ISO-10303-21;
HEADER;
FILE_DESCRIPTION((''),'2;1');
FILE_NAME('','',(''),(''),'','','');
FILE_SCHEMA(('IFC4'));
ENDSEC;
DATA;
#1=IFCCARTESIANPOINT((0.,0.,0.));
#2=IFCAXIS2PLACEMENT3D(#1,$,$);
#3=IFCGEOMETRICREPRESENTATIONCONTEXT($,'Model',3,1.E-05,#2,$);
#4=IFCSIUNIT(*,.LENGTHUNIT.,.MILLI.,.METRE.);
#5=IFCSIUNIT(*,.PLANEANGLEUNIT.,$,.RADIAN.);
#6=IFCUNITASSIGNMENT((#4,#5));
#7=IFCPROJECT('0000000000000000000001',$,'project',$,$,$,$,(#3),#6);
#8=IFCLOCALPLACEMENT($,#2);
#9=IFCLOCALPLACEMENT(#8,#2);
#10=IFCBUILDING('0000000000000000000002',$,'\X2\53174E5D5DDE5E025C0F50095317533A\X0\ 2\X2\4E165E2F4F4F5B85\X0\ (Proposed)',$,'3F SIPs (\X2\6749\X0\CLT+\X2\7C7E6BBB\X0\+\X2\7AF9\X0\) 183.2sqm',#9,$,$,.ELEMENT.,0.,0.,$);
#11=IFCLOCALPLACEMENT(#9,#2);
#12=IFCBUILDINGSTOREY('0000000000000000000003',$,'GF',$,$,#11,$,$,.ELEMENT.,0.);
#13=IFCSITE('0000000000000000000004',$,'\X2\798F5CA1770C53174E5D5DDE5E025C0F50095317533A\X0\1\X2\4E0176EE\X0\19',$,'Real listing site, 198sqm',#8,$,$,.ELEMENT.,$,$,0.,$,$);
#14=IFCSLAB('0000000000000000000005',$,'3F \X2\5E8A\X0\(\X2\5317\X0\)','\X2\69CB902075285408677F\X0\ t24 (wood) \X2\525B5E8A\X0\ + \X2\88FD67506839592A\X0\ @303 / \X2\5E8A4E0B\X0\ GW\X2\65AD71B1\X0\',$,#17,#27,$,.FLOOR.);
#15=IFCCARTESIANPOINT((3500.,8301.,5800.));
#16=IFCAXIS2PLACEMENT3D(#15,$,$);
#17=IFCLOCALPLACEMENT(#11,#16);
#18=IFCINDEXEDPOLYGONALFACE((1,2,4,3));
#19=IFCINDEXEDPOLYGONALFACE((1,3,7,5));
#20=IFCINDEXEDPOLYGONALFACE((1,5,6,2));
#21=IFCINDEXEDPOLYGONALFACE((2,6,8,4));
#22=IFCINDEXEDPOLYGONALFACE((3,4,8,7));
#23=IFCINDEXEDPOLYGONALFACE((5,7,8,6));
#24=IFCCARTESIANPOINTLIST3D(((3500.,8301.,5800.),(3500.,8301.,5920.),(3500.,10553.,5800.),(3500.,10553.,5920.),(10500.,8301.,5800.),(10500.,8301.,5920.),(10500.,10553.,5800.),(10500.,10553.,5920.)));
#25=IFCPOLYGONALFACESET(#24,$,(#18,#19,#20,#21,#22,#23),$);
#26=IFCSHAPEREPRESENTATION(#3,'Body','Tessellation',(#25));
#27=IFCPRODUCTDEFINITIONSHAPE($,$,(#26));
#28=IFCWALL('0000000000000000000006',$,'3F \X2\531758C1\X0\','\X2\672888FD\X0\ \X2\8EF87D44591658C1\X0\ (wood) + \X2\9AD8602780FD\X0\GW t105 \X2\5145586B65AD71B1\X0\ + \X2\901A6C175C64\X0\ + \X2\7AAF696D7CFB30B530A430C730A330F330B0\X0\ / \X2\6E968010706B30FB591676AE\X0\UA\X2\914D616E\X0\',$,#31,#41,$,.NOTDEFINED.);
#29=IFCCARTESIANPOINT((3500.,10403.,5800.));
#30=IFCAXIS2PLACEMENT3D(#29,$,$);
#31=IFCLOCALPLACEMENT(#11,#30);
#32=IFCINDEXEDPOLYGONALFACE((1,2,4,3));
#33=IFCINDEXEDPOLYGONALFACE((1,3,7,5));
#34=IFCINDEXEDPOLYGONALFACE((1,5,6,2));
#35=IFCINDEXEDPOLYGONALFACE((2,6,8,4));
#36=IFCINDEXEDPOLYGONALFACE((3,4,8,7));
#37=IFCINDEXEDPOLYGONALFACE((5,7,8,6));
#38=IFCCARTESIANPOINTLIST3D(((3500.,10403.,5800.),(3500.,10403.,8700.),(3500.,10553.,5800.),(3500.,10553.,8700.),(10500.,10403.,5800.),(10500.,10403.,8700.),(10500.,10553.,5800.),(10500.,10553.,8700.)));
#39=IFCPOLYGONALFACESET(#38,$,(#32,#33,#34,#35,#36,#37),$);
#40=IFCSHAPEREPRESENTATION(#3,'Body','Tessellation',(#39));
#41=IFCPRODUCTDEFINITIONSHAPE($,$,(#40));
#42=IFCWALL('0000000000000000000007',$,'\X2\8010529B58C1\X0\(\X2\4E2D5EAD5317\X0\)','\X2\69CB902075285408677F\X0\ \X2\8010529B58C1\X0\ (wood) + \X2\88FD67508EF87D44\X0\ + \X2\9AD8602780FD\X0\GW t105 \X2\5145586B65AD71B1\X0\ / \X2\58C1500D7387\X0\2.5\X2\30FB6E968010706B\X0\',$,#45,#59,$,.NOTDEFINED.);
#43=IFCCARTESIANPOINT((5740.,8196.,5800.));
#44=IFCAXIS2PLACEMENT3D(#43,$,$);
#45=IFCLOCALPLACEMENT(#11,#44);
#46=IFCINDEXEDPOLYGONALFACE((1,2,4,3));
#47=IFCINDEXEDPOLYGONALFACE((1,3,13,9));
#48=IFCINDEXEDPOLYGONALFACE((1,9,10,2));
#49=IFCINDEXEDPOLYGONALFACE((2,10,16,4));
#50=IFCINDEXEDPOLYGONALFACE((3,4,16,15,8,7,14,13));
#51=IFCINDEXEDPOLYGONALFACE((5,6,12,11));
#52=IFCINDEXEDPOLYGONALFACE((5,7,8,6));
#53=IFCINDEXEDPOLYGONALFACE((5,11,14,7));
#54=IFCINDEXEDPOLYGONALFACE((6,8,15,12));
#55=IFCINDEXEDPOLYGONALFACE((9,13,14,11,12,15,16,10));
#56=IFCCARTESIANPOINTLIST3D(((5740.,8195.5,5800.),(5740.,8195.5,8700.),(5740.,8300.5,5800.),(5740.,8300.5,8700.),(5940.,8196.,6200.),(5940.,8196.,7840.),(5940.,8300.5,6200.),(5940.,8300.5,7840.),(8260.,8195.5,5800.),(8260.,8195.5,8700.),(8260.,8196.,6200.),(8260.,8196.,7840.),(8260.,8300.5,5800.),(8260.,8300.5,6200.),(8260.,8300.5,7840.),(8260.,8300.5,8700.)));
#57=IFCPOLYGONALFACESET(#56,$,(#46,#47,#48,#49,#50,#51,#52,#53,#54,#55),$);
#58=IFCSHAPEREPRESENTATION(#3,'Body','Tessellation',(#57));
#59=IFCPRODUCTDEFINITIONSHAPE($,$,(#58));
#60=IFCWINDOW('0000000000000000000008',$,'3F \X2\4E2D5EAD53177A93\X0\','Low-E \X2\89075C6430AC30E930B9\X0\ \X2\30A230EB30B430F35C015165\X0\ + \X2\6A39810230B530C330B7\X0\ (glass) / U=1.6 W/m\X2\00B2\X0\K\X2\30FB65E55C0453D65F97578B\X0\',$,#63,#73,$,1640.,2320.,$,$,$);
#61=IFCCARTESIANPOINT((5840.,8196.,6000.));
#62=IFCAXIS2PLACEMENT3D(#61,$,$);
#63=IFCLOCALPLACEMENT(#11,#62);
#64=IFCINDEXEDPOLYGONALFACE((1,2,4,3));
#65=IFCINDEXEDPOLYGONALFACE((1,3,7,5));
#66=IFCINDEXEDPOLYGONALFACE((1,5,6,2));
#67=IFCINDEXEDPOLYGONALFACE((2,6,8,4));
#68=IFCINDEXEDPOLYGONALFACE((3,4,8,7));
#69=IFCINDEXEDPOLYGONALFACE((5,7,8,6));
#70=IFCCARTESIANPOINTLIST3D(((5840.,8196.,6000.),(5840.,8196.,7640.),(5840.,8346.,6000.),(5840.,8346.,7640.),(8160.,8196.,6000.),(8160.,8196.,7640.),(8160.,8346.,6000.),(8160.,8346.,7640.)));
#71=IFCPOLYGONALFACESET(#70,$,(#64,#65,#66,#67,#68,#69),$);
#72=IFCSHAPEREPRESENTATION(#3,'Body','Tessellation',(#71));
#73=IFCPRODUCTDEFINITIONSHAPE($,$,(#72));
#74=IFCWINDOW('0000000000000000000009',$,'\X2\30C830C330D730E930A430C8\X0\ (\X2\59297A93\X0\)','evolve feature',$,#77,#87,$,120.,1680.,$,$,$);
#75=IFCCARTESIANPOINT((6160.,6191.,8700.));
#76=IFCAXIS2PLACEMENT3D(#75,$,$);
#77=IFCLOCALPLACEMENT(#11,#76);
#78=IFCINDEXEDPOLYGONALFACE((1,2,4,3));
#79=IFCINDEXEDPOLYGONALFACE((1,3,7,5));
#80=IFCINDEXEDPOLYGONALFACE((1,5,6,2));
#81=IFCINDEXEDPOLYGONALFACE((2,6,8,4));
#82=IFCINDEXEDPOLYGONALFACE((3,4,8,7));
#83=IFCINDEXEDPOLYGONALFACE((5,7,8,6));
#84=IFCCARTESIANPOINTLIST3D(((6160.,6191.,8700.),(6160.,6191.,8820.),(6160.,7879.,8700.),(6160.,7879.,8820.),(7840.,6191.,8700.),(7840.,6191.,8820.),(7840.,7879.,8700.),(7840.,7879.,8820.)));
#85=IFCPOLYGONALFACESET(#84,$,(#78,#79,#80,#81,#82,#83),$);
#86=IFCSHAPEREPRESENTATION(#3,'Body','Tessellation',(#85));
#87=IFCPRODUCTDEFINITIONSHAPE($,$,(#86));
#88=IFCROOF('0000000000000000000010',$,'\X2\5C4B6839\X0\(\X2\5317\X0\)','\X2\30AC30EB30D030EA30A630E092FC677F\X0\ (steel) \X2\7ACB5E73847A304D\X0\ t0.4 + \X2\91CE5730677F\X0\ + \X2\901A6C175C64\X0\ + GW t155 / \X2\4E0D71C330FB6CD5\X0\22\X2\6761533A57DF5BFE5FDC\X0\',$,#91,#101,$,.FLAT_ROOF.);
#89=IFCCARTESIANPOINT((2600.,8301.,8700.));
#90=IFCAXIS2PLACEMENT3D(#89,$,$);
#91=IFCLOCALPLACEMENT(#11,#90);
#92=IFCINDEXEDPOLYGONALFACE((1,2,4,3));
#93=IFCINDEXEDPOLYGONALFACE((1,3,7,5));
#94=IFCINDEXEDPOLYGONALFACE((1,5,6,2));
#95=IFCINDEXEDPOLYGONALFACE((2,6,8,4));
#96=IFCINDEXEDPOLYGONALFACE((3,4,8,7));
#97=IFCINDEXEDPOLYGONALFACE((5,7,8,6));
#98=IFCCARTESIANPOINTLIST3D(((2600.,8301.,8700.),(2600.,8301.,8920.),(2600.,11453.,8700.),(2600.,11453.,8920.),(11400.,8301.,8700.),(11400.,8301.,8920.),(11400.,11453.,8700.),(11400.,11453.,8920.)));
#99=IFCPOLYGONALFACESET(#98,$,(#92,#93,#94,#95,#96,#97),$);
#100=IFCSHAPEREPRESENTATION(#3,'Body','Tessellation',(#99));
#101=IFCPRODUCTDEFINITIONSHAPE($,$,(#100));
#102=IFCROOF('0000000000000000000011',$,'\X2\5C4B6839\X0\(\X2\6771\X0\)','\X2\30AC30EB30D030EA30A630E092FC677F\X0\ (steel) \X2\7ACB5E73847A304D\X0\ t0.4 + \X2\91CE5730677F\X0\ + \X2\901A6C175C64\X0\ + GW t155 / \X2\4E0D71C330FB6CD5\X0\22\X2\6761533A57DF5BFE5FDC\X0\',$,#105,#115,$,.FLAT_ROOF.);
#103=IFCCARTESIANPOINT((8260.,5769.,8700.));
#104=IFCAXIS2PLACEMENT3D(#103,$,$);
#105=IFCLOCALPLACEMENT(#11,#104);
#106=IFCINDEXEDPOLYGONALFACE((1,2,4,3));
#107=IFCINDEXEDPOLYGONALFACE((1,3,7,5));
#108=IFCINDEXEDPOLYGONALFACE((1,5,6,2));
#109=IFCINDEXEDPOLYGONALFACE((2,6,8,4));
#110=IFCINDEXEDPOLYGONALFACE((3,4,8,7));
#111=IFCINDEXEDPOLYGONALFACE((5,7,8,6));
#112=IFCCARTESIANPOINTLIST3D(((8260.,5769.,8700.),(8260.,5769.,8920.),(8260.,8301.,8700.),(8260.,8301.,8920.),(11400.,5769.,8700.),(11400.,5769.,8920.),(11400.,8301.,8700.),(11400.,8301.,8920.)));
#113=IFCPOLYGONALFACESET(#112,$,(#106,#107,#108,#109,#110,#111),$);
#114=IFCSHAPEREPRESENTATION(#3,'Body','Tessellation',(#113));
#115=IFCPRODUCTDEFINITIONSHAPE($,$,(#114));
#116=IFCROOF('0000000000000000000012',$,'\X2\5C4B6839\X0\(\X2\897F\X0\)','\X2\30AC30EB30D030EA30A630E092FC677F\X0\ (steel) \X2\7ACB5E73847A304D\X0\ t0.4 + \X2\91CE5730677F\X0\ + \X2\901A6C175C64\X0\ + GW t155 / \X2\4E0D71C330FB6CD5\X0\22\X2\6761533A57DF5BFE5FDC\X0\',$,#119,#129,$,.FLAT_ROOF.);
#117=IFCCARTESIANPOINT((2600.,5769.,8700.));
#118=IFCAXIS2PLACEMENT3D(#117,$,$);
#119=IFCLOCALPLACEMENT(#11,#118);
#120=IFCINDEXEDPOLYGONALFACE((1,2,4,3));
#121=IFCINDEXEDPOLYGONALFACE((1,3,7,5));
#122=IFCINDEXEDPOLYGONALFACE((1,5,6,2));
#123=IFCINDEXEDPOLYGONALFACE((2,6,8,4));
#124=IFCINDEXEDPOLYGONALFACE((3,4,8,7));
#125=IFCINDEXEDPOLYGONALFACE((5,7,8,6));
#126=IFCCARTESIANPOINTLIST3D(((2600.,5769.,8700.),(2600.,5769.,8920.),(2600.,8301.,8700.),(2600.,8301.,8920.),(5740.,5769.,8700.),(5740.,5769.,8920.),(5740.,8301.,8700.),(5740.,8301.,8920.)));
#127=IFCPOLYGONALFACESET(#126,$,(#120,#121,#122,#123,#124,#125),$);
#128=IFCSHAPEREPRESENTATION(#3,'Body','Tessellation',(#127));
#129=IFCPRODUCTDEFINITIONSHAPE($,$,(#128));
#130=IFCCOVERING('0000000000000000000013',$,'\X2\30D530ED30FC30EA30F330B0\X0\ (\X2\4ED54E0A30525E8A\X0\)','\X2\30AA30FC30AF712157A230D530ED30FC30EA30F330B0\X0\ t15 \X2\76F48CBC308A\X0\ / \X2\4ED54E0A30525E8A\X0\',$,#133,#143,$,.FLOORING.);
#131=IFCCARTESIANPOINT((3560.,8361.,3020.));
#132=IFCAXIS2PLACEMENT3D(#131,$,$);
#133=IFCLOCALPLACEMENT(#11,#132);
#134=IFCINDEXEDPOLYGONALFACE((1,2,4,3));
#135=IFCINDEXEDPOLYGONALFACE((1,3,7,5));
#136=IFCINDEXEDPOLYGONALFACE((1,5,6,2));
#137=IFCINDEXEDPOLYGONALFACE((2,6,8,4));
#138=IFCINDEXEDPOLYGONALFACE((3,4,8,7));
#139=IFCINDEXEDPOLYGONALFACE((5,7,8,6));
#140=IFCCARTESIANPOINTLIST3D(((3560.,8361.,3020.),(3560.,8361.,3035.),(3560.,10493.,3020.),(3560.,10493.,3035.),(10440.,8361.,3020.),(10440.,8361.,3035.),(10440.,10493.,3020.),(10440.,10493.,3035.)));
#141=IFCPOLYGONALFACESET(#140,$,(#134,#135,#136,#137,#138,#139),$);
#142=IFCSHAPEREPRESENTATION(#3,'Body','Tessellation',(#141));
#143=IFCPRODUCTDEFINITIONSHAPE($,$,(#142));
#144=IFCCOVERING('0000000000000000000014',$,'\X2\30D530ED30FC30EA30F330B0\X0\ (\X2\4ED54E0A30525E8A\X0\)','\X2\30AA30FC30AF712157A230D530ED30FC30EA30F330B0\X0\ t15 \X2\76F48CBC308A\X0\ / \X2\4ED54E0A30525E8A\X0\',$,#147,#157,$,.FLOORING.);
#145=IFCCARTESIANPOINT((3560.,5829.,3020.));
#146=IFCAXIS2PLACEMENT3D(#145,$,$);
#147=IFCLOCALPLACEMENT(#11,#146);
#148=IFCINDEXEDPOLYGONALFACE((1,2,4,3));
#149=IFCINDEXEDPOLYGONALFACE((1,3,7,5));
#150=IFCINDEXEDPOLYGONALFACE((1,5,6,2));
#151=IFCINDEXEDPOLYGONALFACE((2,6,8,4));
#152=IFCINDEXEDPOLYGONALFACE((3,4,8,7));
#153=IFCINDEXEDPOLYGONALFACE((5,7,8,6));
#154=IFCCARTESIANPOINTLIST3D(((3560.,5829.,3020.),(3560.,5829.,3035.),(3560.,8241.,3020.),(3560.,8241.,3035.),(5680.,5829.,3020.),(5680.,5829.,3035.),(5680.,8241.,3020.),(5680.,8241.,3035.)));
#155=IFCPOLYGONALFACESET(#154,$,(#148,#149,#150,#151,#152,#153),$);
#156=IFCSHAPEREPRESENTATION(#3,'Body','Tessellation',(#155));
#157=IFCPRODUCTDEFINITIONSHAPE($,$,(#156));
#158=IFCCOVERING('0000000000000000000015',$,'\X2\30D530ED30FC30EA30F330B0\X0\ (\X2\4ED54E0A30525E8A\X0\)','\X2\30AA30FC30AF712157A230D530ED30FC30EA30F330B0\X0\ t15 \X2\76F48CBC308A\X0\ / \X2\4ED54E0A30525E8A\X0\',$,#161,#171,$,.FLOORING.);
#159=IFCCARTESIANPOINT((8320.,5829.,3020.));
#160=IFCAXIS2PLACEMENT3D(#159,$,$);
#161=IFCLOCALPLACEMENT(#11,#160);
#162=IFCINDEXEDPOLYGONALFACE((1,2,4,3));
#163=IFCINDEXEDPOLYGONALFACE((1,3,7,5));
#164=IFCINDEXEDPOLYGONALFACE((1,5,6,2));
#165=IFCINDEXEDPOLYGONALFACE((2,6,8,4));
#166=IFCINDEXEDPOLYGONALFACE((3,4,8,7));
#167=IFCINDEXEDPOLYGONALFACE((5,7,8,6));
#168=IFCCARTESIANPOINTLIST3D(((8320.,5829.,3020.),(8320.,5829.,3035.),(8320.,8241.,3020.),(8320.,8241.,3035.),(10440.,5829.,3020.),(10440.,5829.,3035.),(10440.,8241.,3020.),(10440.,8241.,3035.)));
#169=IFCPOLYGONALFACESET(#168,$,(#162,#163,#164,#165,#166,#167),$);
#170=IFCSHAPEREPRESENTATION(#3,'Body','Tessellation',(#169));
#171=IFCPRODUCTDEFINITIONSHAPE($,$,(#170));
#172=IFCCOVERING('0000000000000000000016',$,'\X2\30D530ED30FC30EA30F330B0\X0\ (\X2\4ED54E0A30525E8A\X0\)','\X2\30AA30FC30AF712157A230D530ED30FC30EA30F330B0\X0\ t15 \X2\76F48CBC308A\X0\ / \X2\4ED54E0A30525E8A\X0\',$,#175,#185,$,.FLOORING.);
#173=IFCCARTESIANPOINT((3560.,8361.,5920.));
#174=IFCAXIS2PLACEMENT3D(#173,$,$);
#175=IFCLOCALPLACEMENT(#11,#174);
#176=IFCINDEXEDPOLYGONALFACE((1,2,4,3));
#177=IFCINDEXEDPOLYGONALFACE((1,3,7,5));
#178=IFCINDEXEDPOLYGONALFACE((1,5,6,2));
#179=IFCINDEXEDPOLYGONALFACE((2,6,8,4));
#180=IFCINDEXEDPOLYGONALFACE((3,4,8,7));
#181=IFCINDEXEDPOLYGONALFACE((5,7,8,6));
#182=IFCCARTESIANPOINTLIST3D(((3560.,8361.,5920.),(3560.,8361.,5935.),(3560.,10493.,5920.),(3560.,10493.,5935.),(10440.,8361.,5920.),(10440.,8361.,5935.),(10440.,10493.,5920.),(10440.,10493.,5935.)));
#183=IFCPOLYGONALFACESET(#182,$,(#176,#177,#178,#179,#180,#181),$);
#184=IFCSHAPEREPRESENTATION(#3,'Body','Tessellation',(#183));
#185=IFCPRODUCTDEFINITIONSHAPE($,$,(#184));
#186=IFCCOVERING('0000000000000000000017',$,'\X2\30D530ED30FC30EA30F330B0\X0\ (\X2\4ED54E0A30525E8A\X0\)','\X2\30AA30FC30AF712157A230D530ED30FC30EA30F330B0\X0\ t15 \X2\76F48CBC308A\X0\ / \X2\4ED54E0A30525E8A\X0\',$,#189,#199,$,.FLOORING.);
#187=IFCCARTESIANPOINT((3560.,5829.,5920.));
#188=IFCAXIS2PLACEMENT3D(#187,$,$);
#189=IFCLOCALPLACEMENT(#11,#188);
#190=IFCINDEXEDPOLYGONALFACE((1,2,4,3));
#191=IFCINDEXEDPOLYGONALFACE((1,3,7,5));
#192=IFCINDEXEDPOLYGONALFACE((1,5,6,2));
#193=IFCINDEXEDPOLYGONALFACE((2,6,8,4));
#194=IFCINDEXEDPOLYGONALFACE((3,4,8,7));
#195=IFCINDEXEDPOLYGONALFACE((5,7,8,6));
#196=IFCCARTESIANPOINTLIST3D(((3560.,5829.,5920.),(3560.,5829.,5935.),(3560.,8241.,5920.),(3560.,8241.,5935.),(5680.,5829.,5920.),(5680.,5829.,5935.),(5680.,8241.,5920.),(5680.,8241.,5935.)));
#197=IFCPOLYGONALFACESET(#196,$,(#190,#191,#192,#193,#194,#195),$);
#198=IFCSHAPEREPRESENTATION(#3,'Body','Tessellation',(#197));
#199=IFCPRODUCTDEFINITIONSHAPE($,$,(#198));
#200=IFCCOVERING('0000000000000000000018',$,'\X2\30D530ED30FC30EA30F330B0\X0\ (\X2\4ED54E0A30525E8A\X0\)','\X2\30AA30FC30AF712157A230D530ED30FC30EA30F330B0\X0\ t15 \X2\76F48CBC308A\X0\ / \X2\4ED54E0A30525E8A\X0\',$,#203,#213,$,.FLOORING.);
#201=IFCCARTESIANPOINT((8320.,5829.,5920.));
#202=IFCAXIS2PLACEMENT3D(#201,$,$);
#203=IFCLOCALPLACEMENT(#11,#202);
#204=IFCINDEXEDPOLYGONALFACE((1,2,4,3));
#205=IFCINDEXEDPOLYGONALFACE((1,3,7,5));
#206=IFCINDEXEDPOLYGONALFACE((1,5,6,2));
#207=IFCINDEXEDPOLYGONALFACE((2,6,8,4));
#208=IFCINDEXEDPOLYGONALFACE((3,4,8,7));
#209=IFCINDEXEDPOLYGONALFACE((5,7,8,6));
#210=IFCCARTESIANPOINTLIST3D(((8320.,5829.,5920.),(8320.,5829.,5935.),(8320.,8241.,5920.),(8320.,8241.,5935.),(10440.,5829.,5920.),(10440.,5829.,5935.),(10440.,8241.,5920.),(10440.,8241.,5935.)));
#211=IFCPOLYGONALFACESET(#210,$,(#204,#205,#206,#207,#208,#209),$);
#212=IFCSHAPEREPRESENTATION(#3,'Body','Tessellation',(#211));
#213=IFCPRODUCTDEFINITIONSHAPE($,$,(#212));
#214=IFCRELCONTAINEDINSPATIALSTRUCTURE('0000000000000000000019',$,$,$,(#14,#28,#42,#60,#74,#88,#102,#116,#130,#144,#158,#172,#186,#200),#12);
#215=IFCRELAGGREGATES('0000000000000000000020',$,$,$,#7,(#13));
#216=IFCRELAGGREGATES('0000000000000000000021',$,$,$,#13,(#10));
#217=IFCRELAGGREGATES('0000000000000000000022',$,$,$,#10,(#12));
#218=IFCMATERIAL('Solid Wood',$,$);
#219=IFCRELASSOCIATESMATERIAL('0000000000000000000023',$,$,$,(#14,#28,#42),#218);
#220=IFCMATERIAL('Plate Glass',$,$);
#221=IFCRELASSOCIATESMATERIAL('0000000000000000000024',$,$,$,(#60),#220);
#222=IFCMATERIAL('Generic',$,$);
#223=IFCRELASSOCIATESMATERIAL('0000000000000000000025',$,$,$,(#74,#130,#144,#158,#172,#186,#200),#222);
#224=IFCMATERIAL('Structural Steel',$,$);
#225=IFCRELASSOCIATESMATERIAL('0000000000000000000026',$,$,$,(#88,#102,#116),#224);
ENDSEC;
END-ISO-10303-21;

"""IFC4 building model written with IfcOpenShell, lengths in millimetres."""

from ifc_helpers import new_model, si_unit, frame, frame_2d, origin, place, context, project, spatial, rectangle, extrude, material, element, fill, save


model = new_model("IFC4")

# Units and contexts
model_context = context("Model", 3, precision=1e-05, world=origin())
ifc_project = project(units=[si_unit("LENGTHUNIT", "METRE", prefix="MILLI"), si_unit("PLANEANGLEUNIT", "RADIAN")], contexts=[model_context])

# Site, building, storey
site_placement = place(None, origin())
site = spatial("IfcSite", under=ifc_project, at=site_placement, Name="福岡県北九州市小倉北区1丁目19", ObjectType="Real listing site, 198sqm", CompositionType="ELEMENT", RefElevation=0.0)
building_placement = place(site_placement, origin())
building = spatial("IfcBuilding", under=site, at=building_placement, Name="北九州市小倉北区 2世帯住宅 (Proposed)", ObjectType="3F SIPs (杉CLT+籾殻+竹) 183.2sqm", CompositionType="ELEMENT", ElevationOfRefHeight=0.0, ElevationOfTerrain=0.0)
storey_placement = place(building_placement, origin())
storey = spatial("IfcBuildingStorey", under=building, at=storey_placement, Name="GF", CompositionType="ELEMENT", Elevation=0.0)

# Slab
ifc_material_1 = material(Name="Solid Wood")
slab_placement = place(storey_placement, frame((3500.0, 8301.0, 5800.0)))
element("IfcSlab", 1, at=slab_placement, inside=storey, material=ifc_material_1, Name="3F 床(北)", Description="構造用合板 t24 (wood) 剛床 + 製材根太 @303 / 床下 GW断熱", PredefinedType="FLOOR", context=model_context, shape_type="SweptSolid", body=[
    extrude(rectangle(XDim=7000.0, YDim=2252.0, at=frame_2d((3500.0, 1126.0))), frame((3500.0, 8301.0, 5800.0)), (0.0, 0.0, 1.0), 120.0),
])

# Wall
wall_1_placement = place(storey_placement, frame((3500.0, 10403.0, 5800.0)))
element("IfcWall", 2, at=wall_1_placement, inside=storey, material=ifc_material_1, Name="3F 北壁", Description="木製 軸組外壁 (wood) + 高性能GW t105 充填断熱 + 通気層 + 窯業系サイディング / 準耐火・外皮UA配慮", PredefinedType="NOTDEFINED", context=model_context, shape_type="SweptSolid", body=[
    extrude(rectangle(XDim=7000.0, YDim=150.0, at=frame_2d((3500.0, 75.0))), frame((3500.0, 10403.0, 5800.0)), (0.0, 0.0, 1.0), 2900.0),
])

# Wall, opening, window
wall_2_placement = place(storey_placement, frame((5740.0, 8196.0, 5800.0)))
wall_2 = element("IfcWall", 3, at=wall_2_placement, inside=storey, material=ifc_material_1, Name="耐力壁(中庭北)", Description="構造用合板 耐力壁 (wood) + 製材軸組 + 高性能GW t105 充填断熱 / 壁倍率2.5・準耐火", PredefinedType="NOTDEFINED", context=model_context, shape_type="SweptSolid", body=[
    extrude(rectangle(XDim=2520.0, YDim=105.0, at=frame_2d((1260.0, 52.0))), frame((5740.0, 8196.0, 5800.0)), (0.0, 0.0, 1.0), 2900.0),
])
opening_placement = place(storey_placement, frame((5840.0, 8196.0, 6000.0)))
opening = element("IfcOpeningElement", 4, at=opening_placement, cuts=wall_2, PredefinedType="NOTDEFINED", context=model_context, shape_type="SweptSolid", body=[
    extrude(rectangle(XDim=2320.0, YDim=150.0, at=frame_2d((1160.0, 75.0))), frame((5840.0, 8196.0, 6000.0)), (0.0, 0.0, 1.0), 1640.0),
])
ifc_material_2 = material(Name="Plate Glass")
window_1_placement = place(storey_placement, frame((5840.0, 8196.0, 6000.0)))
window_1 = element("IfcWindow", 5, at=window_1_placement, inside=storey, material=ifc_material_2, Name="3F 中庭北窓", Description="Low-E 複層ガラス アルゴン封入 + 樹脂サッシ (glass) / U=1.6 W/m²K・日射取得型", OverallHeight=1640.0, OverallWidth=2320.0, context=model_context, shape_type="SweptSolid", body=[
    extrude(rectangle(XDim=2320.0, YDim=150.0, at=frame_2d((1160.0, 75.0))), frame((5840.0, 8196.0, 6000.0)), (0.0, 0.0, 1.0), 1640.0),
])
fill(opening, window_1)

# Window
ifc_material_3 = material(Name="Generic")
window_2_placement = place(storey_placement, frame((6160.0, 6191.0, 8700.0)))
element("IfcWindow", 6, at=window_2_placement, inside=storey, material=ifc_material_3, Name="トップライト (天窓)", Description="evolve feature", OverallHeight=120.0, OverallWidth=1680.0, context=model_context, shape_type="SweptSolid", body=[
    extrude(rectangle(XDim=1680.0, YDim=1688.0, at=frame_2d((840.0, 844.0))), frame((6160.0, 6191.0, 8700.0)), (0.0, 0.0, 1.0), 120.0),
])

# Roofs
ifc_material_4 = material(Name="Structural Steel")
roof_1_placement = place(storey_placement, frame((2600.0, 8301.0, 8700.0)))
element("IfcRoof", 7, at=roof_1_placement, inside=storey, material=ifc_material_4, Name="屋根(北)", Description="ガルバリウム鋼板 (steel) 立平葺き t0.4 + 野地板 + 通気層 + GW t155 / 不燃・法22条区域対応", PredefinedType="FLAT_ROOF", context=model_context, shape_type="SweptSolid", body=[
    extrude(rectangle(XDim=8800.0, YDim=3152.0, at=frame_2d((4400.0, 1576.0))), frame((2600.0, 8301.0, 8700.0)), (0.0, 0.0, 1.0), 220.0),
])
roof_2_placement = place(storey_placement, frame((8260.0, 5769.0, 8700.0)))
element("IfcRoof", 8, at=roof_2_placement, inside=storey, material=ifc_material_4, Name="屋根(東)", Description="ガルバリウム鋼板 (steel) 立平葺き t0.4 + 野地板 + 通気層 + GW t155 / 不燃・法22条区域対応", PredefinedType="FLAT_ROOF", context=model_context, shape_type="SweptSolid", body=[
    extrude(rectangle(XDim=3140.0, YDim=2532.0, at=frame_2d((1570.0, 1266.0))), frame((8260.0, 5769.0, 8700.0)), (0.0, 0.0, 1.0), 220.0),
])
roof_3_placement = place(storey_placement, frame((2600.0, 5769.0, 8700.0)))
element("IfcRoof", 9, at=roof_3_placement, inside=storey, material=ifc_material_4, Name="屋根(西)", Description="ガルバリウム鋼板 (steel) 立平葺き t0.4 + 野地板 + 通気層 + GW t155 / 不燃・法22条区域対応", PredefinedType="FLAT_ROOF", context=model_context, shape_type="SweptSolid", body=[
    extrude(rectangle(XDim=3140.0, YDim=2532.0, at=frame_2d((1570.0, 1266.0))), frame((2600.0, 5769.0, 8700.0)), (0.0, 0.0, 1.0), 220.0),
])

# Coverings
covering_1_placement = place(storey_placement, frame((3560.0, 8361.0, 3020.0)))
element("IfcCovering", 10, at=covering_1_placement, inside=storey, material=ifc_material_3, Name="フローリング (仕上げ床)", Description="オーク無垢フローリング t15 直貼り / 仕上げ床", PredefinedType="FLOORING", context=model_context, shape_type="SweptSolid", body=[
    extrude(rectangle(XDim=6880.0, YDim=2132.0, at=frame_2d((3440.0, 1066.0))), frame((3560.0, 8361.0, 3020.0)), (0.0, 0.0, 1.0), 15.0),
])
covering_2_placement = place(storey_placement, frame((3560.0, 5829.0, 3020.0)))
element("IfcCovering", 11, at=covering_2_placement, inside=storey, material=ifc_material_3, Name="フローリング (仕上げ床)", Description="オーク無垢フローリング t15 直貼り / 仕上げ床", PredefinedType="FLOORING", context=model_context, shape_type="SweptSolid", body=[
    extrude(rectangle(XDim=2120.0, YDim=2412.0, at=frame_2d((1060.0, 1206.0))), frame((3560.0, 5829.0, 3020.0)), (0.0, 0.0, 1.0), 15.0),
])
covering_3_placement = place(storey_placement, frame((8320.0, 5829.0, 3020.0)))
element("IfcCovering", 12, at=covering_3_placement, inside=storey, material=ifc_material_3, Name="フローリング (仕上げ床)", Description="オーク無垢フローリング t15 直貼り / 仕上げ床", PredefinedType="FLOORING", context=model_context, shape_type="SweptSolid", body=[
    extrude(rectangle(XDim=2120.0, YDim=2412.0, at=frame_2d((1060.0, 1206.0))), frame((8320.0, 5829.0, 3020.0)), (0.0, 0.0, 1.0), 15.0),
])
covering_4_placement = place(storey_placement, frame((3560.0, 8361.0, 5920.0)))
element("IfcCovering", 13, at=covering_4_placement, inside=storey, material=ifc_material_3, Name="フローリング (仕上げ床)", Description="オーク無垢フローリング t15 直貼り / 仕上げ床", PredefinedType="FLOORING", context=model_context, shape_type="SweptSolid", body=[
    extrude(rectangle(XDim=6880.0, YDim=2132.0, at=frame_2d((3440.0, 1066.0))), frame((3560.0, 8361.0, 5920.0)), (0.0, 0.0, 1.0), 15.0),
])
covering_5_placement = place(storey_placement, frame((3560.0, 5829.0, 5920.0)))
element("IfcCovering", 14, at=covering_5_placement, inside=storey, material=ifc_material_3, Name="フローリング (仕上げ床)", Description="オーク無垢フローリング t15 直貼り / 仕上げ床", PredefinedType="FLOORING", context=model_context, shape_type="SweptSolid", body=[
    extrude(rectangle(XDim=2120.0, YDim=2412.0, at=frame_2d((1060.0, 1206.0))), frame((3560.0, 5829.0, 5920.0)), (0.0, 0.0, 1.0), 15.0),
])
covering_6_placement = place(storey_placement, frame((8320.0, 5829.0, 5920.0)))
element("IfcCovering", 15, at=covering_6_placement, inside=storey, material=ifc_material_3, Name="フローリング (仕上げ床)", Description="オーク無垢フローリング t15 直貼り / 仕上げ床", PredefinedType="FLOORING", context=model_context, shape_type="SweptSolid", body=[
    extrude(rectangle(XDim=2120.0, YDim=2412.0, at=frame_2d((1060.0, 1206.0))), frame((8320.0, 5829.0, 5920.0)), (0.0, 0.0, 1.0), 15.0),
])

save(model, "model.ifc")
